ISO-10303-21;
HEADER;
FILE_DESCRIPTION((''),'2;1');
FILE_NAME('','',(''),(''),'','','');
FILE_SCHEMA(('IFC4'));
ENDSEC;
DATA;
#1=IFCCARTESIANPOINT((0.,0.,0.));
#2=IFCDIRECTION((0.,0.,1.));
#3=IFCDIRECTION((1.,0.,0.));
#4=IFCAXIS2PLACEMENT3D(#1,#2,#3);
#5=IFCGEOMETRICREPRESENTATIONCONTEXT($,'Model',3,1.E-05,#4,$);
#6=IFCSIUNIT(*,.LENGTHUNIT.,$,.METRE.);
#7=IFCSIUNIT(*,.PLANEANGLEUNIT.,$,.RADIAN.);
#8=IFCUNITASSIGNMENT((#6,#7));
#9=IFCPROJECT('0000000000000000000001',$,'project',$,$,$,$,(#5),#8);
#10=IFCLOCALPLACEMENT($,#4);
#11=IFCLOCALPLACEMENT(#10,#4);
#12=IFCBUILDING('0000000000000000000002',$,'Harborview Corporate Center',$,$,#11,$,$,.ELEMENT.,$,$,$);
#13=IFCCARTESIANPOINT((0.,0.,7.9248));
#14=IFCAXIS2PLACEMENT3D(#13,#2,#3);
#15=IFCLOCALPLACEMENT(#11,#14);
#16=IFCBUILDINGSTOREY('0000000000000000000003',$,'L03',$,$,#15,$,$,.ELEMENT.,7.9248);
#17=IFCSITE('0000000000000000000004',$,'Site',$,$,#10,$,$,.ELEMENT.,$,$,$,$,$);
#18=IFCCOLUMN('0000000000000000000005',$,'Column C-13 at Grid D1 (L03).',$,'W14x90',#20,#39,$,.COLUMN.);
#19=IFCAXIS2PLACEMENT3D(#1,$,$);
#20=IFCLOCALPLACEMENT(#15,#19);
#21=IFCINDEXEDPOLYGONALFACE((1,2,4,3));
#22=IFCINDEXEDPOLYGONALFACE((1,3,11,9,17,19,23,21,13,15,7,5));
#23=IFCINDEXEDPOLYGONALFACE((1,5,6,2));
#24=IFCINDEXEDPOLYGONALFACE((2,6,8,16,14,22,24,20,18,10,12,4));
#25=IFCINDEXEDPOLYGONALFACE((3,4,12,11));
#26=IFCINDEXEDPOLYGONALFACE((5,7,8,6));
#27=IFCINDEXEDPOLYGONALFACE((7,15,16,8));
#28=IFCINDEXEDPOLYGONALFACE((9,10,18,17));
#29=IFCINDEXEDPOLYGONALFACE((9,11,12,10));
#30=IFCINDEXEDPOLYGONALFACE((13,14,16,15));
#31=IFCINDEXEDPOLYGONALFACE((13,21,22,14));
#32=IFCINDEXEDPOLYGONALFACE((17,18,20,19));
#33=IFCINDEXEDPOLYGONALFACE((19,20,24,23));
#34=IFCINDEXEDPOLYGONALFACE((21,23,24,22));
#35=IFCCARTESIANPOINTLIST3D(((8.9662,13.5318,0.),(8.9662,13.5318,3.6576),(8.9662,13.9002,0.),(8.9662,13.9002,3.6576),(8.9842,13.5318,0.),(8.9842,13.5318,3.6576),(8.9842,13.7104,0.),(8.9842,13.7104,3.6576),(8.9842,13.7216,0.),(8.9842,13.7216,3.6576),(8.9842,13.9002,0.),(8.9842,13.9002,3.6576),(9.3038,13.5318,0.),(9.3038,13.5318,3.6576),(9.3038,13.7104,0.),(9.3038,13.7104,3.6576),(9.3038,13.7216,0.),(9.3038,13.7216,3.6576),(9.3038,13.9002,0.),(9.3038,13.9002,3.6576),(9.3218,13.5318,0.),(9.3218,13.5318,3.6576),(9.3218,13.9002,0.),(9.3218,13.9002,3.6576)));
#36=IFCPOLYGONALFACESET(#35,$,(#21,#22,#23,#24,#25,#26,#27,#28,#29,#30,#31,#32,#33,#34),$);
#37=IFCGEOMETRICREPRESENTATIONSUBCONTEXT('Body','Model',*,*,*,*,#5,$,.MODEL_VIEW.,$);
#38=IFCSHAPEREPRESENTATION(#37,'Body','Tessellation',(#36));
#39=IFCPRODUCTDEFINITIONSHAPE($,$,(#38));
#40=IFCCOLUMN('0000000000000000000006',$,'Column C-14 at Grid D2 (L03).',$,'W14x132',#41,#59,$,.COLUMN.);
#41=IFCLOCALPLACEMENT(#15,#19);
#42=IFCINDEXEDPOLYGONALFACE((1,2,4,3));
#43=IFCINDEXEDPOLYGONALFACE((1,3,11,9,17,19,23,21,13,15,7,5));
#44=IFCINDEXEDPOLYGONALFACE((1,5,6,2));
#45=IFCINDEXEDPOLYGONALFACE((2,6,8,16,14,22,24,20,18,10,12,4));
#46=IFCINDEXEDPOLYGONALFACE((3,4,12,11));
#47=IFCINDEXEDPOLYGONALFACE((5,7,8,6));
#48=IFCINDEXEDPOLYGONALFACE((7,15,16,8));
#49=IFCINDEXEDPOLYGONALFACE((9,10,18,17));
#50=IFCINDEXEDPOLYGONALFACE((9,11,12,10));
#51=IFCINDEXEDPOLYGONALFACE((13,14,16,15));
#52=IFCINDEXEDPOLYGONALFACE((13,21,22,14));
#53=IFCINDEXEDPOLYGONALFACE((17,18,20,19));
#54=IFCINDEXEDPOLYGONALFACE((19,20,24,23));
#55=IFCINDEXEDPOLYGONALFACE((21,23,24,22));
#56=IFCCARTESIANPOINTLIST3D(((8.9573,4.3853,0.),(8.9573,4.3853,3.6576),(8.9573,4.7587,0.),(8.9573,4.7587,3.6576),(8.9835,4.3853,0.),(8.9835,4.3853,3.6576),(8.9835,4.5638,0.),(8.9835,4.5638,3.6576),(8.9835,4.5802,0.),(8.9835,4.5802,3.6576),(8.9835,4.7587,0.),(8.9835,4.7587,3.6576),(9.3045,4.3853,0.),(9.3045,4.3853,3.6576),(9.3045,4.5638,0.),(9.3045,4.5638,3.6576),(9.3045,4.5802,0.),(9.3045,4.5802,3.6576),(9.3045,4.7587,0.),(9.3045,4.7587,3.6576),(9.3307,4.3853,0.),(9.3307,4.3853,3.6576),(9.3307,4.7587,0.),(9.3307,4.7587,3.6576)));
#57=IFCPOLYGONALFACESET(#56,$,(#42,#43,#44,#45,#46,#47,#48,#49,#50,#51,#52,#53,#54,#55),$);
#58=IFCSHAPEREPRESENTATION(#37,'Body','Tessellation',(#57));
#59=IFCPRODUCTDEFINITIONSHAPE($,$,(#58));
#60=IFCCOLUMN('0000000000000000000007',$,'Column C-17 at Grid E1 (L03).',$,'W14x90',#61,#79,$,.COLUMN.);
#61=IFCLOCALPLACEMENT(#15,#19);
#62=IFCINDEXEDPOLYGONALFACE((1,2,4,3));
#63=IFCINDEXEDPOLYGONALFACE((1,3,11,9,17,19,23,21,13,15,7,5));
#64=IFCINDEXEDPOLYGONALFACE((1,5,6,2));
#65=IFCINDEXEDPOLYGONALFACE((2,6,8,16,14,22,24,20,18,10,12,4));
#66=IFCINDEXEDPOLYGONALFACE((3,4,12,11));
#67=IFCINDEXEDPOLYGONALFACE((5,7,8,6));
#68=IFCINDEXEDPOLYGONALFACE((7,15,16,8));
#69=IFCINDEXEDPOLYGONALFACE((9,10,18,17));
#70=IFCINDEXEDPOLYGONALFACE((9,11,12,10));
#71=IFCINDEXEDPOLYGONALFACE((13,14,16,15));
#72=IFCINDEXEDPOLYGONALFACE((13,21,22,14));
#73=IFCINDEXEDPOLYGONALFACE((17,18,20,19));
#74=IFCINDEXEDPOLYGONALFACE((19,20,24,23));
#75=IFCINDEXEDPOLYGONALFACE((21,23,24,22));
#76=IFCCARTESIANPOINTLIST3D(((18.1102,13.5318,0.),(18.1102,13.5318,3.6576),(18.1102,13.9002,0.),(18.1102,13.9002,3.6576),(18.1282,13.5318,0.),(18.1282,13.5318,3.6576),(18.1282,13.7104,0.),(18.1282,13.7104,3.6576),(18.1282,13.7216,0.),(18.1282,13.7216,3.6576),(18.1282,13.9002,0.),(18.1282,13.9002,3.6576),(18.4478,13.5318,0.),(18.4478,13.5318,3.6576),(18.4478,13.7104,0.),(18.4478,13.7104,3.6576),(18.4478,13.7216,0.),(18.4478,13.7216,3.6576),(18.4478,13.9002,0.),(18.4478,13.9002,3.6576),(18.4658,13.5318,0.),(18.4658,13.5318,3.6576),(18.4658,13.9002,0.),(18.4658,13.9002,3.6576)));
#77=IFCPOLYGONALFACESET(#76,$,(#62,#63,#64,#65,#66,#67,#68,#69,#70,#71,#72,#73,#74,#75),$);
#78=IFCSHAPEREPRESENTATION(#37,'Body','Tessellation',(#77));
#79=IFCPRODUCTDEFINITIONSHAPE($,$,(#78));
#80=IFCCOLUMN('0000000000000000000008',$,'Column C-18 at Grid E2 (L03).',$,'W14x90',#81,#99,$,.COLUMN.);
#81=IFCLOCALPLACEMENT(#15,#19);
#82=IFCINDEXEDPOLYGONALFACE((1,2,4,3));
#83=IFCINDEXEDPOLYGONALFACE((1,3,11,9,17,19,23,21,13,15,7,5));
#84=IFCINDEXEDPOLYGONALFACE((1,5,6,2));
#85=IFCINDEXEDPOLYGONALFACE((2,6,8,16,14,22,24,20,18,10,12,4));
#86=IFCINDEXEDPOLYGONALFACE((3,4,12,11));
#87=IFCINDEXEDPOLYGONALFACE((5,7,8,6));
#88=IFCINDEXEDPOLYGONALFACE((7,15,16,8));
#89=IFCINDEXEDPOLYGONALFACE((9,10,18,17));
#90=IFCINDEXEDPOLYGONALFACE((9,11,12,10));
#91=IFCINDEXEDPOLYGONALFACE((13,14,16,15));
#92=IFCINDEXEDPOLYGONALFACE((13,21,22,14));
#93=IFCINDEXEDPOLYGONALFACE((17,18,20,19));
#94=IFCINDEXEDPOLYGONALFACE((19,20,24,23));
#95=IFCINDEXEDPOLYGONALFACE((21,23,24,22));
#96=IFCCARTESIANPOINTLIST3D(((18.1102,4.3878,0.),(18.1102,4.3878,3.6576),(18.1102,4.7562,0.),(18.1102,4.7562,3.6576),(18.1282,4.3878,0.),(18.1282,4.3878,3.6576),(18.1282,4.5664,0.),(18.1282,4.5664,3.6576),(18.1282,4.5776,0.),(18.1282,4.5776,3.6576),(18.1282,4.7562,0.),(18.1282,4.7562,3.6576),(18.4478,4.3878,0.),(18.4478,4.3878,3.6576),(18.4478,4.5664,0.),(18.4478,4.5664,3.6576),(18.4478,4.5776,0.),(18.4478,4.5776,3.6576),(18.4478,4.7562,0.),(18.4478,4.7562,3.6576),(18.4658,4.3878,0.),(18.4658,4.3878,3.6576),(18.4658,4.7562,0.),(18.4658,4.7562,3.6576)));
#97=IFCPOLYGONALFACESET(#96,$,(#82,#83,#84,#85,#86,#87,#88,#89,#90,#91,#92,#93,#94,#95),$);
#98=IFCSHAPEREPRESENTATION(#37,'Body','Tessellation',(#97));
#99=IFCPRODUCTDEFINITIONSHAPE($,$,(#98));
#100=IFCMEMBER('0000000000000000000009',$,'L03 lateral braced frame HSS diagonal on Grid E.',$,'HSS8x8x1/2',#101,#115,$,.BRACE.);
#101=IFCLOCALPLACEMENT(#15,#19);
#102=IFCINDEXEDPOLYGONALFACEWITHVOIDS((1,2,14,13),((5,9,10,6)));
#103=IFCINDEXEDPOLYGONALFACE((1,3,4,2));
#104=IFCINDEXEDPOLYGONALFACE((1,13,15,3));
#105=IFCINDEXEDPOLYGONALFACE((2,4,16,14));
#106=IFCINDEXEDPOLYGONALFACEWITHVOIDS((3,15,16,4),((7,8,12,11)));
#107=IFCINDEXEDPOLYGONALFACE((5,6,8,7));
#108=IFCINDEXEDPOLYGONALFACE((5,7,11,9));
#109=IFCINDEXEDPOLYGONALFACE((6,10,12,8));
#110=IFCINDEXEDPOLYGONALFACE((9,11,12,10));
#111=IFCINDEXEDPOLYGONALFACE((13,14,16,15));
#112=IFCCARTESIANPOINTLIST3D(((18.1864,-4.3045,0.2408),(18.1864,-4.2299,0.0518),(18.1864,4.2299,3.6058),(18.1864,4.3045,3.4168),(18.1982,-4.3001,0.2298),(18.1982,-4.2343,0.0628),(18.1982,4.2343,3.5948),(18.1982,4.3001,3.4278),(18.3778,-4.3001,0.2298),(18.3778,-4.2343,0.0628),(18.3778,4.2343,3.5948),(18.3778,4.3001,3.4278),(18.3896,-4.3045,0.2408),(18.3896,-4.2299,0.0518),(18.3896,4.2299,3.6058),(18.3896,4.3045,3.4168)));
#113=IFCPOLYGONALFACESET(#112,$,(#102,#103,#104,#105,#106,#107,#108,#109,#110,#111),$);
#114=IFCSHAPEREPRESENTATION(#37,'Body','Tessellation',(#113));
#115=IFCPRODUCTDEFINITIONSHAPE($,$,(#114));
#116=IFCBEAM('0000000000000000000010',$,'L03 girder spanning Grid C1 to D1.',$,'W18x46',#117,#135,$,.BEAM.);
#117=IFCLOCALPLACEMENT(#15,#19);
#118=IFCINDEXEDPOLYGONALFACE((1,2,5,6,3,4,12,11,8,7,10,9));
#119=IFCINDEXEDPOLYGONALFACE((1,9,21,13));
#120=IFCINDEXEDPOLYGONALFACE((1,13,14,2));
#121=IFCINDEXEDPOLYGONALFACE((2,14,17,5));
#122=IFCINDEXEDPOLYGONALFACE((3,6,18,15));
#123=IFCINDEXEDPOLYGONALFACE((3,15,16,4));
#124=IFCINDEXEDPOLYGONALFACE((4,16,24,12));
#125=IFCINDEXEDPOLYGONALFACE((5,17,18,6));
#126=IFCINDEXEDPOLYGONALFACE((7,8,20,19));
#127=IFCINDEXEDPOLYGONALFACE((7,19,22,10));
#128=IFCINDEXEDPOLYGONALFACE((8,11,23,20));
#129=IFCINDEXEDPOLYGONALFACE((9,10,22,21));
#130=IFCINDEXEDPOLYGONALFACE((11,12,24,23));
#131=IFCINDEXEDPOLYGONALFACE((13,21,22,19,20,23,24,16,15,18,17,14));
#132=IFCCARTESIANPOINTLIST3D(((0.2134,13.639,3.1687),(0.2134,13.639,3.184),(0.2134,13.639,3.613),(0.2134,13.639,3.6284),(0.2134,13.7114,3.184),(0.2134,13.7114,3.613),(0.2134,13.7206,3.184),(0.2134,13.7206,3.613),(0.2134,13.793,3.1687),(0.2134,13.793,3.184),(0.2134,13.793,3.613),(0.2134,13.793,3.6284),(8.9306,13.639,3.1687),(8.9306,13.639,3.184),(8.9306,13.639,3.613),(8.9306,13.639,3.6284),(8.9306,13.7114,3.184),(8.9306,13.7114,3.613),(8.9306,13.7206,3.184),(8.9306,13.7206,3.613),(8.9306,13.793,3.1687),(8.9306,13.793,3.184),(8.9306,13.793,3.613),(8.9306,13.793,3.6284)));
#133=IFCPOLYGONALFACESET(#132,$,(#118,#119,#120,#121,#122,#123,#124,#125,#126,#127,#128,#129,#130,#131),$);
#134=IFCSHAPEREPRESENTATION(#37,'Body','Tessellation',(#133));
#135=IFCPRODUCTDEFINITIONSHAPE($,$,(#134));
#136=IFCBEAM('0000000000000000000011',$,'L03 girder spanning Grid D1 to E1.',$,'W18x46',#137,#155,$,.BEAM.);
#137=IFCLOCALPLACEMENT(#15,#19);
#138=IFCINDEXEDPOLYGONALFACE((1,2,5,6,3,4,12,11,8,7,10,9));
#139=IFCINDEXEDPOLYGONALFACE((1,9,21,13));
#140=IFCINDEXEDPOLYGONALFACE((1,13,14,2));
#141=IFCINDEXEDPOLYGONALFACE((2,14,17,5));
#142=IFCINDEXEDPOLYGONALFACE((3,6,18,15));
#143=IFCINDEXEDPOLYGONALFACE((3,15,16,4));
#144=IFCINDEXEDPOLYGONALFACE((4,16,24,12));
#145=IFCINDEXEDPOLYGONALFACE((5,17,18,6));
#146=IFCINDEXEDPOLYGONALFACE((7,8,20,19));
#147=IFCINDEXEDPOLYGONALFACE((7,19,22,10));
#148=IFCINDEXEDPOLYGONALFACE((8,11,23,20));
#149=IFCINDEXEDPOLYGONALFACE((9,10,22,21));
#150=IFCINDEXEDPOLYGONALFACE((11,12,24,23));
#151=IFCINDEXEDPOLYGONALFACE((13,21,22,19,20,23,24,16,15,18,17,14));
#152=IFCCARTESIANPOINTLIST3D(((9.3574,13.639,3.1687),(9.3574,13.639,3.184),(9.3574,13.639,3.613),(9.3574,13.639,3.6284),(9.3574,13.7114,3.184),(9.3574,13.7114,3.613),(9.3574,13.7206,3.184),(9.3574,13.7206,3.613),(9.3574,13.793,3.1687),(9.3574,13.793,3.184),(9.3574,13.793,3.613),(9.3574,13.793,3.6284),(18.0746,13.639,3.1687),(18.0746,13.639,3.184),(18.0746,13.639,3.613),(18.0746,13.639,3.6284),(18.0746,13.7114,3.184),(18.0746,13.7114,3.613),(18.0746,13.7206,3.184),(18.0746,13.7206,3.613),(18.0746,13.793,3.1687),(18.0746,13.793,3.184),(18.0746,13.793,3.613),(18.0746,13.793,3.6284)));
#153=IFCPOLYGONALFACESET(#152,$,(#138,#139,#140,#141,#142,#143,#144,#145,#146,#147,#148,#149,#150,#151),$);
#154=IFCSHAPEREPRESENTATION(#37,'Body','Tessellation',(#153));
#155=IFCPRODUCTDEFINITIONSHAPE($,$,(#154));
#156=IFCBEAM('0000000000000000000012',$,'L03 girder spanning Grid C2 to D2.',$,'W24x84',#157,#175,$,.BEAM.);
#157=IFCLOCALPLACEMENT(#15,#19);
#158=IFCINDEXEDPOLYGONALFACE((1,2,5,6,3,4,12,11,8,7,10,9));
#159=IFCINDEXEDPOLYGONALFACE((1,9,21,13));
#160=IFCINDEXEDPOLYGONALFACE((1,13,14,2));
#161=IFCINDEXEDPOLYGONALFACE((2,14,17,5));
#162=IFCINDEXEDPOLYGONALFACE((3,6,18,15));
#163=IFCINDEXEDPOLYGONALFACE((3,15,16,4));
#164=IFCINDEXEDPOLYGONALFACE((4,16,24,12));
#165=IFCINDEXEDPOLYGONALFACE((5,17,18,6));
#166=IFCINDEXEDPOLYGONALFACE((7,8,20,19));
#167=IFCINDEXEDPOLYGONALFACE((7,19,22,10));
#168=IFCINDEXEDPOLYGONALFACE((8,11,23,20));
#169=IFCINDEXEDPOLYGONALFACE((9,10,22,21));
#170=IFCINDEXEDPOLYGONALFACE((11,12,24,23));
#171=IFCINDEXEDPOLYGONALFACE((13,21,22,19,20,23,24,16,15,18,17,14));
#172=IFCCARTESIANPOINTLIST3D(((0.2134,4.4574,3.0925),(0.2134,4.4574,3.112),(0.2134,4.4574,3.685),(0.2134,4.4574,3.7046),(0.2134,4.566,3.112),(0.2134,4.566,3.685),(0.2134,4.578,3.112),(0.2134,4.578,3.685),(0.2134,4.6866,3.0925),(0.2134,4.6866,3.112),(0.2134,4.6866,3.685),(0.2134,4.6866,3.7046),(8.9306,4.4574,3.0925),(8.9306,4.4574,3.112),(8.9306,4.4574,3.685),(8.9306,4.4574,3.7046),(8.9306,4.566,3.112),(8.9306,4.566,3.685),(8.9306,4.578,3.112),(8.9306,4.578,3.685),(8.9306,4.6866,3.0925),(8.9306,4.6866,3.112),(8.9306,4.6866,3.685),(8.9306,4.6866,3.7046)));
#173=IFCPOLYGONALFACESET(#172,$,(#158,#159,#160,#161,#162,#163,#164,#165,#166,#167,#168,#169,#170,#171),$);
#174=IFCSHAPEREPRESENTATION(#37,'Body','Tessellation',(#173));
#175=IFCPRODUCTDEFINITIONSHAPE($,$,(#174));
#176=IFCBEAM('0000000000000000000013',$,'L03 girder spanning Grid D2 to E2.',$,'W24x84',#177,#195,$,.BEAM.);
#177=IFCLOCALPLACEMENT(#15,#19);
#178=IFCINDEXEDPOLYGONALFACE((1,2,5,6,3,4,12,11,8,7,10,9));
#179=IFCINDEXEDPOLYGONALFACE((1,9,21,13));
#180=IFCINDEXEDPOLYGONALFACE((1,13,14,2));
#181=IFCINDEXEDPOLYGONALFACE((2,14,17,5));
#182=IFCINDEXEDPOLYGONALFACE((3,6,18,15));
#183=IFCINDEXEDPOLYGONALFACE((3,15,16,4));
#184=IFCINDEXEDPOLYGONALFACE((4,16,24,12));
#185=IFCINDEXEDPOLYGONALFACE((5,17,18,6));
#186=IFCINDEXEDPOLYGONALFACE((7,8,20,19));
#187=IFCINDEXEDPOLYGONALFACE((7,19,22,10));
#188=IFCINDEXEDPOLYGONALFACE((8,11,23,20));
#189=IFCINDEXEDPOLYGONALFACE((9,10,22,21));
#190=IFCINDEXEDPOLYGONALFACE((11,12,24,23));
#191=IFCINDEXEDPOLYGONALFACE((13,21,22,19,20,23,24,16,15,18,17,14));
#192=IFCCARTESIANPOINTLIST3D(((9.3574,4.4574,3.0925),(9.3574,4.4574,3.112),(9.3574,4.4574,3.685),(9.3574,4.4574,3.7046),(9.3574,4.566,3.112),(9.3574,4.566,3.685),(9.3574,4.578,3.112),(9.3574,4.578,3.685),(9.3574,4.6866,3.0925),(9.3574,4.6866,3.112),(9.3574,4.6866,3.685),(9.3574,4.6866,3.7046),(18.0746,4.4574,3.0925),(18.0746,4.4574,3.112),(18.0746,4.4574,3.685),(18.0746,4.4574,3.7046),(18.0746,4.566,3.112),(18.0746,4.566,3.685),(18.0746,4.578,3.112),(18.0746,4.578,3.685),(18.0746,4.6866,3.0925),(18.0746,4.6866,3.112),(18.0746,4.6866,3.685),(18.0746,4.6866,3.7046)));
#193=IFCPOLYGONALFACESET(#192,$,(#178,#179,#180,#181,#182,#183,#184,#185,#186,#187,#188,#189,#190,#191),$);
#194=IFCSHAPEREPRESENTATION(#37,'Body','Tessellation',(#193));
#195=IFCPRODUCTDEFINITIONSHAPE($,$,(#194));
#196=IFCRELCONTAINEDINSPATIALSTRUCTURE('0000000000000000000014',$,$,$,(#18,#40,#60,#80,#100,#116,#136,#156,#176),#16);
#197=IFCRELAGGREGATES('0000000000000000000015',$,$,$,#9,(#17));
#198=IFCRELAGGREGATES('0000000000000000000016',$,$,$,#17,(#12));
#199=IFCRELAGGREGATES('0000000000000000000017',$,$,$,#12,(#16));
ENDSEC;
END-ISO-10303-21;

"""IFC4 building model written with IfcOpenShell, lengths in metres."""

from ifc_helpers import new_model, si_unit, frame, origin_with_axes, place, context, subcontext, project, spatial, hollow_rectangle, i_section, extrude, element, save


model = new_model("IFC4")

# Units and contexts
model_context = context("Model", 3, precision=1e-05, world=origin_with_axes())
body_context = subcontext(model_context, "Body", "Model", "MODEL_VIEW")
ifc_project = project(units=[si_unit("LENGTHUNIT", "METRE"), si_unit("PLANEANGLEUNIT", "RADIAN")], contexts=[model_context])

# Site, building, storey
site_placement = place(None, origin_with_axes())
site = spatial("IfcSite", under=ifc_project, at=site_placement, Name="Site", CompositionType="ELEMENT")
building_placement = place(site_placement, origin_with_axes())
building = spatial("IfcBuilding", under=site, at=building_placement, Name="Harborview Corporate Center", CompositionType="ELEMENT")
storey_placement = place(building_placement, frame((0.0, 0.0, 7.9248), z_axis=(0.0, 0.0, 1.0), x_axis=(1.0, 0.0, 0.0)))
storey = spatial("IfcBuildingStorey", under=building, at=storey_placement, Name="L03", CompositionType="ELEMENT", Elevation=7.9248)

# Columns
column_1_placement = place(storey_placement, frame((9.144, 13.716, 0.0), z_axis=(0.0, 0.0, 1.0), x_axis=(0.0, 1.0, 0.0)))
element("IfcColumn", 1, at=column_1_placement, inside=storey, Name="Column C-13 at Grid D1 (L03).", ObjectType="W14x90", PredefinedType="COLUMN", context=body_context, shape_type="SweptSolid", body=[
    extrude(i_section(OverallWidth=0.3683, OverallDepth=0.3556, WebThickness=0.0112, FlangeThickness=0.018), origin_with_axes(), (0.0, 0.0, 1.0), 3.6576),
])
column_2_placement = place(storey_placement, frame((9.144, 4.572, 0.0), z_axis=(0.0, 0.0, 1.0), x_axis=(0.0, 1.0, 0.0)))
element("IfcColumn", 2, at=column_2_placement, inside=storey, Name="Column C-14 at Grid D2 (L03).", ObjectType="W14x132", PredefinedType="COLUMN", context=body_context, shape_type="SweptSolid", body=[
    extrude(i_section(OverallWidth=0.3734, OverallDepth=0.3734, WebThickness=0.0164, FlangeThickness=0.0262), origin_with_axes(), (0.0, 0.0, 1.0), 3.6576),
])
for number, where, z_axis, x_axis, name in (
    (3, (18.288, 13.716, 0.0), (0.0, 0.0, 1.0), (0.0, 1.0, 0.0), "Column C-17 at Grid E1 (L03)."),
    (4, (18.288, 4.572, 0.0), (0.0, 0.0, 1.0), (0.0, 1.0, 0.0), "Column C-18 at Grid E2 (L03)."),
):
    element("IfcColumn", number, at=place(storey_placement, frame(where, z_axis=z_axis, x_axis=x_axis)), inside=storey, Name=name, ObjectType="W14x90", PredefinedType="COLUMN", context=body_context, shape_type="SweptSolid", body=[
        extrude(i_section(OverallWidth=0.3683, OverallDepth=0.3556, WebThickness=0.0112, FlangeThickness=0.018), origin_with_axes(), (0.0, 0.0, 1.0), 3.6576),
    ])

# Member
member_placement = place(storey_placement, frame((18.288, -4.2672, 0.1463), z_axis=(0.0, 0.930298, 0.366803), x_axis=(-1.0, 0.0, 0.0)))
element("IfcMember", 5, at=member_placement, inside=storey, Name="L03 lateral braced frame HSS diagonal on Grid E.", ObjectType="HSS8x8x1/2", PredefinedType="BRACE", context=body_context, shape_type="SweptSolid", body=[
    extrude(hollow_rectangle(XDim=0.2032, YDim=0.2032, WallThickness=0.0118), origin_with_axes(), (0.0, 0.0, 1.0), 9.1738),
])

# Beams
beam_1_placement = place(storey_placement, frame((0.2134, 13.716, 3.3985), z_axis=(1.0, 0.0, 0.0), x_axis=(0.0, 1.0, 0.0)))
element("IfcBeam", 6, at=beam_1_placement, inside=storey, Name="L03 girder spanning Grid C1 to D1.", ObjectType="W18x46", PredefinedType="BEAM", context=body_context, shape_type="SweptSolid", body=[
    extrude(i_section(OverallWidth=0.1539, OverallDepth=0.4597, WebThickness=0.0091, FlangeThickness=0.0154), origin_with_axes(), (0.0, 0.0, 1.0), 8.7173),
])
beam_2_placement = place(storey_placement, frame((9.3574, 13.716, 3.3985), z_axis=(1.0, 0.0, 0.0), x_axis=(0.0, 1.0, 0.0)))
element("IfcBeam", 7, at=beam_2_placement, inside=storey, Name="L03 girder spanning Grid D1 to E1.", ObjectType="W18x46", PredefinedType="BEAM", context=body_context, shape_type="SweptSolid", body=[
    extrude(i_section(OverallWidth=0.1539, OverallDepth=0.4597, WebThickness=0.0091, FlangeThickness=0.0154), origin_with_axes(), (0.0, 0.0, 1.0), 8.7173),
])
beam_3_placement = place(storey_placement, frame((0.2134, 4.572, 3.3985), z_axis=(1.0, 0.0, 0.0), x_axis=(0.0, 1.0, 0.0)))
element("IfcBeam", 8, at=beam_3_placement, inside=storey, Name="L03 girder spanning Grid C2 to D2.", ObjectType="W24x84", PredefinedType="BEAM", context=body_context, shape_type="SweptSolid", body=[
    extrude(i_section(OverallWidth=0.2291, OverallDepth=0.6121, WebThickness=0.0119, FlangeThickness=0.0196), origin_with_axes(), (0.0, 0.0, 1.0), 8.7173),
])
beam_4_placement = place(storey_placement, frame((9.3574, 4.572, 3.3985), z_axis=(1.0, 0.0, 0.0), x_axis=(0.0, 1.0, 0.0)))
element("IfcBeam", 9, at=beam_4_placement, inside=storey, Name="L03 girder spanning Grid D2 to E2.", ObjectType="W24x84", PredefinedType="BEAM", context=body_context, shape_type="SweptSolid", body=[
    extrude(i_section(OverallWidth=0.2291, OverallDepth=0.6121, WebThickness=0.0119, FlangeThickness=0.0196), origin_with_axes(), (0.0, 0.0, 1.0), 8.7173),
])

save(model, "model.ifc")
